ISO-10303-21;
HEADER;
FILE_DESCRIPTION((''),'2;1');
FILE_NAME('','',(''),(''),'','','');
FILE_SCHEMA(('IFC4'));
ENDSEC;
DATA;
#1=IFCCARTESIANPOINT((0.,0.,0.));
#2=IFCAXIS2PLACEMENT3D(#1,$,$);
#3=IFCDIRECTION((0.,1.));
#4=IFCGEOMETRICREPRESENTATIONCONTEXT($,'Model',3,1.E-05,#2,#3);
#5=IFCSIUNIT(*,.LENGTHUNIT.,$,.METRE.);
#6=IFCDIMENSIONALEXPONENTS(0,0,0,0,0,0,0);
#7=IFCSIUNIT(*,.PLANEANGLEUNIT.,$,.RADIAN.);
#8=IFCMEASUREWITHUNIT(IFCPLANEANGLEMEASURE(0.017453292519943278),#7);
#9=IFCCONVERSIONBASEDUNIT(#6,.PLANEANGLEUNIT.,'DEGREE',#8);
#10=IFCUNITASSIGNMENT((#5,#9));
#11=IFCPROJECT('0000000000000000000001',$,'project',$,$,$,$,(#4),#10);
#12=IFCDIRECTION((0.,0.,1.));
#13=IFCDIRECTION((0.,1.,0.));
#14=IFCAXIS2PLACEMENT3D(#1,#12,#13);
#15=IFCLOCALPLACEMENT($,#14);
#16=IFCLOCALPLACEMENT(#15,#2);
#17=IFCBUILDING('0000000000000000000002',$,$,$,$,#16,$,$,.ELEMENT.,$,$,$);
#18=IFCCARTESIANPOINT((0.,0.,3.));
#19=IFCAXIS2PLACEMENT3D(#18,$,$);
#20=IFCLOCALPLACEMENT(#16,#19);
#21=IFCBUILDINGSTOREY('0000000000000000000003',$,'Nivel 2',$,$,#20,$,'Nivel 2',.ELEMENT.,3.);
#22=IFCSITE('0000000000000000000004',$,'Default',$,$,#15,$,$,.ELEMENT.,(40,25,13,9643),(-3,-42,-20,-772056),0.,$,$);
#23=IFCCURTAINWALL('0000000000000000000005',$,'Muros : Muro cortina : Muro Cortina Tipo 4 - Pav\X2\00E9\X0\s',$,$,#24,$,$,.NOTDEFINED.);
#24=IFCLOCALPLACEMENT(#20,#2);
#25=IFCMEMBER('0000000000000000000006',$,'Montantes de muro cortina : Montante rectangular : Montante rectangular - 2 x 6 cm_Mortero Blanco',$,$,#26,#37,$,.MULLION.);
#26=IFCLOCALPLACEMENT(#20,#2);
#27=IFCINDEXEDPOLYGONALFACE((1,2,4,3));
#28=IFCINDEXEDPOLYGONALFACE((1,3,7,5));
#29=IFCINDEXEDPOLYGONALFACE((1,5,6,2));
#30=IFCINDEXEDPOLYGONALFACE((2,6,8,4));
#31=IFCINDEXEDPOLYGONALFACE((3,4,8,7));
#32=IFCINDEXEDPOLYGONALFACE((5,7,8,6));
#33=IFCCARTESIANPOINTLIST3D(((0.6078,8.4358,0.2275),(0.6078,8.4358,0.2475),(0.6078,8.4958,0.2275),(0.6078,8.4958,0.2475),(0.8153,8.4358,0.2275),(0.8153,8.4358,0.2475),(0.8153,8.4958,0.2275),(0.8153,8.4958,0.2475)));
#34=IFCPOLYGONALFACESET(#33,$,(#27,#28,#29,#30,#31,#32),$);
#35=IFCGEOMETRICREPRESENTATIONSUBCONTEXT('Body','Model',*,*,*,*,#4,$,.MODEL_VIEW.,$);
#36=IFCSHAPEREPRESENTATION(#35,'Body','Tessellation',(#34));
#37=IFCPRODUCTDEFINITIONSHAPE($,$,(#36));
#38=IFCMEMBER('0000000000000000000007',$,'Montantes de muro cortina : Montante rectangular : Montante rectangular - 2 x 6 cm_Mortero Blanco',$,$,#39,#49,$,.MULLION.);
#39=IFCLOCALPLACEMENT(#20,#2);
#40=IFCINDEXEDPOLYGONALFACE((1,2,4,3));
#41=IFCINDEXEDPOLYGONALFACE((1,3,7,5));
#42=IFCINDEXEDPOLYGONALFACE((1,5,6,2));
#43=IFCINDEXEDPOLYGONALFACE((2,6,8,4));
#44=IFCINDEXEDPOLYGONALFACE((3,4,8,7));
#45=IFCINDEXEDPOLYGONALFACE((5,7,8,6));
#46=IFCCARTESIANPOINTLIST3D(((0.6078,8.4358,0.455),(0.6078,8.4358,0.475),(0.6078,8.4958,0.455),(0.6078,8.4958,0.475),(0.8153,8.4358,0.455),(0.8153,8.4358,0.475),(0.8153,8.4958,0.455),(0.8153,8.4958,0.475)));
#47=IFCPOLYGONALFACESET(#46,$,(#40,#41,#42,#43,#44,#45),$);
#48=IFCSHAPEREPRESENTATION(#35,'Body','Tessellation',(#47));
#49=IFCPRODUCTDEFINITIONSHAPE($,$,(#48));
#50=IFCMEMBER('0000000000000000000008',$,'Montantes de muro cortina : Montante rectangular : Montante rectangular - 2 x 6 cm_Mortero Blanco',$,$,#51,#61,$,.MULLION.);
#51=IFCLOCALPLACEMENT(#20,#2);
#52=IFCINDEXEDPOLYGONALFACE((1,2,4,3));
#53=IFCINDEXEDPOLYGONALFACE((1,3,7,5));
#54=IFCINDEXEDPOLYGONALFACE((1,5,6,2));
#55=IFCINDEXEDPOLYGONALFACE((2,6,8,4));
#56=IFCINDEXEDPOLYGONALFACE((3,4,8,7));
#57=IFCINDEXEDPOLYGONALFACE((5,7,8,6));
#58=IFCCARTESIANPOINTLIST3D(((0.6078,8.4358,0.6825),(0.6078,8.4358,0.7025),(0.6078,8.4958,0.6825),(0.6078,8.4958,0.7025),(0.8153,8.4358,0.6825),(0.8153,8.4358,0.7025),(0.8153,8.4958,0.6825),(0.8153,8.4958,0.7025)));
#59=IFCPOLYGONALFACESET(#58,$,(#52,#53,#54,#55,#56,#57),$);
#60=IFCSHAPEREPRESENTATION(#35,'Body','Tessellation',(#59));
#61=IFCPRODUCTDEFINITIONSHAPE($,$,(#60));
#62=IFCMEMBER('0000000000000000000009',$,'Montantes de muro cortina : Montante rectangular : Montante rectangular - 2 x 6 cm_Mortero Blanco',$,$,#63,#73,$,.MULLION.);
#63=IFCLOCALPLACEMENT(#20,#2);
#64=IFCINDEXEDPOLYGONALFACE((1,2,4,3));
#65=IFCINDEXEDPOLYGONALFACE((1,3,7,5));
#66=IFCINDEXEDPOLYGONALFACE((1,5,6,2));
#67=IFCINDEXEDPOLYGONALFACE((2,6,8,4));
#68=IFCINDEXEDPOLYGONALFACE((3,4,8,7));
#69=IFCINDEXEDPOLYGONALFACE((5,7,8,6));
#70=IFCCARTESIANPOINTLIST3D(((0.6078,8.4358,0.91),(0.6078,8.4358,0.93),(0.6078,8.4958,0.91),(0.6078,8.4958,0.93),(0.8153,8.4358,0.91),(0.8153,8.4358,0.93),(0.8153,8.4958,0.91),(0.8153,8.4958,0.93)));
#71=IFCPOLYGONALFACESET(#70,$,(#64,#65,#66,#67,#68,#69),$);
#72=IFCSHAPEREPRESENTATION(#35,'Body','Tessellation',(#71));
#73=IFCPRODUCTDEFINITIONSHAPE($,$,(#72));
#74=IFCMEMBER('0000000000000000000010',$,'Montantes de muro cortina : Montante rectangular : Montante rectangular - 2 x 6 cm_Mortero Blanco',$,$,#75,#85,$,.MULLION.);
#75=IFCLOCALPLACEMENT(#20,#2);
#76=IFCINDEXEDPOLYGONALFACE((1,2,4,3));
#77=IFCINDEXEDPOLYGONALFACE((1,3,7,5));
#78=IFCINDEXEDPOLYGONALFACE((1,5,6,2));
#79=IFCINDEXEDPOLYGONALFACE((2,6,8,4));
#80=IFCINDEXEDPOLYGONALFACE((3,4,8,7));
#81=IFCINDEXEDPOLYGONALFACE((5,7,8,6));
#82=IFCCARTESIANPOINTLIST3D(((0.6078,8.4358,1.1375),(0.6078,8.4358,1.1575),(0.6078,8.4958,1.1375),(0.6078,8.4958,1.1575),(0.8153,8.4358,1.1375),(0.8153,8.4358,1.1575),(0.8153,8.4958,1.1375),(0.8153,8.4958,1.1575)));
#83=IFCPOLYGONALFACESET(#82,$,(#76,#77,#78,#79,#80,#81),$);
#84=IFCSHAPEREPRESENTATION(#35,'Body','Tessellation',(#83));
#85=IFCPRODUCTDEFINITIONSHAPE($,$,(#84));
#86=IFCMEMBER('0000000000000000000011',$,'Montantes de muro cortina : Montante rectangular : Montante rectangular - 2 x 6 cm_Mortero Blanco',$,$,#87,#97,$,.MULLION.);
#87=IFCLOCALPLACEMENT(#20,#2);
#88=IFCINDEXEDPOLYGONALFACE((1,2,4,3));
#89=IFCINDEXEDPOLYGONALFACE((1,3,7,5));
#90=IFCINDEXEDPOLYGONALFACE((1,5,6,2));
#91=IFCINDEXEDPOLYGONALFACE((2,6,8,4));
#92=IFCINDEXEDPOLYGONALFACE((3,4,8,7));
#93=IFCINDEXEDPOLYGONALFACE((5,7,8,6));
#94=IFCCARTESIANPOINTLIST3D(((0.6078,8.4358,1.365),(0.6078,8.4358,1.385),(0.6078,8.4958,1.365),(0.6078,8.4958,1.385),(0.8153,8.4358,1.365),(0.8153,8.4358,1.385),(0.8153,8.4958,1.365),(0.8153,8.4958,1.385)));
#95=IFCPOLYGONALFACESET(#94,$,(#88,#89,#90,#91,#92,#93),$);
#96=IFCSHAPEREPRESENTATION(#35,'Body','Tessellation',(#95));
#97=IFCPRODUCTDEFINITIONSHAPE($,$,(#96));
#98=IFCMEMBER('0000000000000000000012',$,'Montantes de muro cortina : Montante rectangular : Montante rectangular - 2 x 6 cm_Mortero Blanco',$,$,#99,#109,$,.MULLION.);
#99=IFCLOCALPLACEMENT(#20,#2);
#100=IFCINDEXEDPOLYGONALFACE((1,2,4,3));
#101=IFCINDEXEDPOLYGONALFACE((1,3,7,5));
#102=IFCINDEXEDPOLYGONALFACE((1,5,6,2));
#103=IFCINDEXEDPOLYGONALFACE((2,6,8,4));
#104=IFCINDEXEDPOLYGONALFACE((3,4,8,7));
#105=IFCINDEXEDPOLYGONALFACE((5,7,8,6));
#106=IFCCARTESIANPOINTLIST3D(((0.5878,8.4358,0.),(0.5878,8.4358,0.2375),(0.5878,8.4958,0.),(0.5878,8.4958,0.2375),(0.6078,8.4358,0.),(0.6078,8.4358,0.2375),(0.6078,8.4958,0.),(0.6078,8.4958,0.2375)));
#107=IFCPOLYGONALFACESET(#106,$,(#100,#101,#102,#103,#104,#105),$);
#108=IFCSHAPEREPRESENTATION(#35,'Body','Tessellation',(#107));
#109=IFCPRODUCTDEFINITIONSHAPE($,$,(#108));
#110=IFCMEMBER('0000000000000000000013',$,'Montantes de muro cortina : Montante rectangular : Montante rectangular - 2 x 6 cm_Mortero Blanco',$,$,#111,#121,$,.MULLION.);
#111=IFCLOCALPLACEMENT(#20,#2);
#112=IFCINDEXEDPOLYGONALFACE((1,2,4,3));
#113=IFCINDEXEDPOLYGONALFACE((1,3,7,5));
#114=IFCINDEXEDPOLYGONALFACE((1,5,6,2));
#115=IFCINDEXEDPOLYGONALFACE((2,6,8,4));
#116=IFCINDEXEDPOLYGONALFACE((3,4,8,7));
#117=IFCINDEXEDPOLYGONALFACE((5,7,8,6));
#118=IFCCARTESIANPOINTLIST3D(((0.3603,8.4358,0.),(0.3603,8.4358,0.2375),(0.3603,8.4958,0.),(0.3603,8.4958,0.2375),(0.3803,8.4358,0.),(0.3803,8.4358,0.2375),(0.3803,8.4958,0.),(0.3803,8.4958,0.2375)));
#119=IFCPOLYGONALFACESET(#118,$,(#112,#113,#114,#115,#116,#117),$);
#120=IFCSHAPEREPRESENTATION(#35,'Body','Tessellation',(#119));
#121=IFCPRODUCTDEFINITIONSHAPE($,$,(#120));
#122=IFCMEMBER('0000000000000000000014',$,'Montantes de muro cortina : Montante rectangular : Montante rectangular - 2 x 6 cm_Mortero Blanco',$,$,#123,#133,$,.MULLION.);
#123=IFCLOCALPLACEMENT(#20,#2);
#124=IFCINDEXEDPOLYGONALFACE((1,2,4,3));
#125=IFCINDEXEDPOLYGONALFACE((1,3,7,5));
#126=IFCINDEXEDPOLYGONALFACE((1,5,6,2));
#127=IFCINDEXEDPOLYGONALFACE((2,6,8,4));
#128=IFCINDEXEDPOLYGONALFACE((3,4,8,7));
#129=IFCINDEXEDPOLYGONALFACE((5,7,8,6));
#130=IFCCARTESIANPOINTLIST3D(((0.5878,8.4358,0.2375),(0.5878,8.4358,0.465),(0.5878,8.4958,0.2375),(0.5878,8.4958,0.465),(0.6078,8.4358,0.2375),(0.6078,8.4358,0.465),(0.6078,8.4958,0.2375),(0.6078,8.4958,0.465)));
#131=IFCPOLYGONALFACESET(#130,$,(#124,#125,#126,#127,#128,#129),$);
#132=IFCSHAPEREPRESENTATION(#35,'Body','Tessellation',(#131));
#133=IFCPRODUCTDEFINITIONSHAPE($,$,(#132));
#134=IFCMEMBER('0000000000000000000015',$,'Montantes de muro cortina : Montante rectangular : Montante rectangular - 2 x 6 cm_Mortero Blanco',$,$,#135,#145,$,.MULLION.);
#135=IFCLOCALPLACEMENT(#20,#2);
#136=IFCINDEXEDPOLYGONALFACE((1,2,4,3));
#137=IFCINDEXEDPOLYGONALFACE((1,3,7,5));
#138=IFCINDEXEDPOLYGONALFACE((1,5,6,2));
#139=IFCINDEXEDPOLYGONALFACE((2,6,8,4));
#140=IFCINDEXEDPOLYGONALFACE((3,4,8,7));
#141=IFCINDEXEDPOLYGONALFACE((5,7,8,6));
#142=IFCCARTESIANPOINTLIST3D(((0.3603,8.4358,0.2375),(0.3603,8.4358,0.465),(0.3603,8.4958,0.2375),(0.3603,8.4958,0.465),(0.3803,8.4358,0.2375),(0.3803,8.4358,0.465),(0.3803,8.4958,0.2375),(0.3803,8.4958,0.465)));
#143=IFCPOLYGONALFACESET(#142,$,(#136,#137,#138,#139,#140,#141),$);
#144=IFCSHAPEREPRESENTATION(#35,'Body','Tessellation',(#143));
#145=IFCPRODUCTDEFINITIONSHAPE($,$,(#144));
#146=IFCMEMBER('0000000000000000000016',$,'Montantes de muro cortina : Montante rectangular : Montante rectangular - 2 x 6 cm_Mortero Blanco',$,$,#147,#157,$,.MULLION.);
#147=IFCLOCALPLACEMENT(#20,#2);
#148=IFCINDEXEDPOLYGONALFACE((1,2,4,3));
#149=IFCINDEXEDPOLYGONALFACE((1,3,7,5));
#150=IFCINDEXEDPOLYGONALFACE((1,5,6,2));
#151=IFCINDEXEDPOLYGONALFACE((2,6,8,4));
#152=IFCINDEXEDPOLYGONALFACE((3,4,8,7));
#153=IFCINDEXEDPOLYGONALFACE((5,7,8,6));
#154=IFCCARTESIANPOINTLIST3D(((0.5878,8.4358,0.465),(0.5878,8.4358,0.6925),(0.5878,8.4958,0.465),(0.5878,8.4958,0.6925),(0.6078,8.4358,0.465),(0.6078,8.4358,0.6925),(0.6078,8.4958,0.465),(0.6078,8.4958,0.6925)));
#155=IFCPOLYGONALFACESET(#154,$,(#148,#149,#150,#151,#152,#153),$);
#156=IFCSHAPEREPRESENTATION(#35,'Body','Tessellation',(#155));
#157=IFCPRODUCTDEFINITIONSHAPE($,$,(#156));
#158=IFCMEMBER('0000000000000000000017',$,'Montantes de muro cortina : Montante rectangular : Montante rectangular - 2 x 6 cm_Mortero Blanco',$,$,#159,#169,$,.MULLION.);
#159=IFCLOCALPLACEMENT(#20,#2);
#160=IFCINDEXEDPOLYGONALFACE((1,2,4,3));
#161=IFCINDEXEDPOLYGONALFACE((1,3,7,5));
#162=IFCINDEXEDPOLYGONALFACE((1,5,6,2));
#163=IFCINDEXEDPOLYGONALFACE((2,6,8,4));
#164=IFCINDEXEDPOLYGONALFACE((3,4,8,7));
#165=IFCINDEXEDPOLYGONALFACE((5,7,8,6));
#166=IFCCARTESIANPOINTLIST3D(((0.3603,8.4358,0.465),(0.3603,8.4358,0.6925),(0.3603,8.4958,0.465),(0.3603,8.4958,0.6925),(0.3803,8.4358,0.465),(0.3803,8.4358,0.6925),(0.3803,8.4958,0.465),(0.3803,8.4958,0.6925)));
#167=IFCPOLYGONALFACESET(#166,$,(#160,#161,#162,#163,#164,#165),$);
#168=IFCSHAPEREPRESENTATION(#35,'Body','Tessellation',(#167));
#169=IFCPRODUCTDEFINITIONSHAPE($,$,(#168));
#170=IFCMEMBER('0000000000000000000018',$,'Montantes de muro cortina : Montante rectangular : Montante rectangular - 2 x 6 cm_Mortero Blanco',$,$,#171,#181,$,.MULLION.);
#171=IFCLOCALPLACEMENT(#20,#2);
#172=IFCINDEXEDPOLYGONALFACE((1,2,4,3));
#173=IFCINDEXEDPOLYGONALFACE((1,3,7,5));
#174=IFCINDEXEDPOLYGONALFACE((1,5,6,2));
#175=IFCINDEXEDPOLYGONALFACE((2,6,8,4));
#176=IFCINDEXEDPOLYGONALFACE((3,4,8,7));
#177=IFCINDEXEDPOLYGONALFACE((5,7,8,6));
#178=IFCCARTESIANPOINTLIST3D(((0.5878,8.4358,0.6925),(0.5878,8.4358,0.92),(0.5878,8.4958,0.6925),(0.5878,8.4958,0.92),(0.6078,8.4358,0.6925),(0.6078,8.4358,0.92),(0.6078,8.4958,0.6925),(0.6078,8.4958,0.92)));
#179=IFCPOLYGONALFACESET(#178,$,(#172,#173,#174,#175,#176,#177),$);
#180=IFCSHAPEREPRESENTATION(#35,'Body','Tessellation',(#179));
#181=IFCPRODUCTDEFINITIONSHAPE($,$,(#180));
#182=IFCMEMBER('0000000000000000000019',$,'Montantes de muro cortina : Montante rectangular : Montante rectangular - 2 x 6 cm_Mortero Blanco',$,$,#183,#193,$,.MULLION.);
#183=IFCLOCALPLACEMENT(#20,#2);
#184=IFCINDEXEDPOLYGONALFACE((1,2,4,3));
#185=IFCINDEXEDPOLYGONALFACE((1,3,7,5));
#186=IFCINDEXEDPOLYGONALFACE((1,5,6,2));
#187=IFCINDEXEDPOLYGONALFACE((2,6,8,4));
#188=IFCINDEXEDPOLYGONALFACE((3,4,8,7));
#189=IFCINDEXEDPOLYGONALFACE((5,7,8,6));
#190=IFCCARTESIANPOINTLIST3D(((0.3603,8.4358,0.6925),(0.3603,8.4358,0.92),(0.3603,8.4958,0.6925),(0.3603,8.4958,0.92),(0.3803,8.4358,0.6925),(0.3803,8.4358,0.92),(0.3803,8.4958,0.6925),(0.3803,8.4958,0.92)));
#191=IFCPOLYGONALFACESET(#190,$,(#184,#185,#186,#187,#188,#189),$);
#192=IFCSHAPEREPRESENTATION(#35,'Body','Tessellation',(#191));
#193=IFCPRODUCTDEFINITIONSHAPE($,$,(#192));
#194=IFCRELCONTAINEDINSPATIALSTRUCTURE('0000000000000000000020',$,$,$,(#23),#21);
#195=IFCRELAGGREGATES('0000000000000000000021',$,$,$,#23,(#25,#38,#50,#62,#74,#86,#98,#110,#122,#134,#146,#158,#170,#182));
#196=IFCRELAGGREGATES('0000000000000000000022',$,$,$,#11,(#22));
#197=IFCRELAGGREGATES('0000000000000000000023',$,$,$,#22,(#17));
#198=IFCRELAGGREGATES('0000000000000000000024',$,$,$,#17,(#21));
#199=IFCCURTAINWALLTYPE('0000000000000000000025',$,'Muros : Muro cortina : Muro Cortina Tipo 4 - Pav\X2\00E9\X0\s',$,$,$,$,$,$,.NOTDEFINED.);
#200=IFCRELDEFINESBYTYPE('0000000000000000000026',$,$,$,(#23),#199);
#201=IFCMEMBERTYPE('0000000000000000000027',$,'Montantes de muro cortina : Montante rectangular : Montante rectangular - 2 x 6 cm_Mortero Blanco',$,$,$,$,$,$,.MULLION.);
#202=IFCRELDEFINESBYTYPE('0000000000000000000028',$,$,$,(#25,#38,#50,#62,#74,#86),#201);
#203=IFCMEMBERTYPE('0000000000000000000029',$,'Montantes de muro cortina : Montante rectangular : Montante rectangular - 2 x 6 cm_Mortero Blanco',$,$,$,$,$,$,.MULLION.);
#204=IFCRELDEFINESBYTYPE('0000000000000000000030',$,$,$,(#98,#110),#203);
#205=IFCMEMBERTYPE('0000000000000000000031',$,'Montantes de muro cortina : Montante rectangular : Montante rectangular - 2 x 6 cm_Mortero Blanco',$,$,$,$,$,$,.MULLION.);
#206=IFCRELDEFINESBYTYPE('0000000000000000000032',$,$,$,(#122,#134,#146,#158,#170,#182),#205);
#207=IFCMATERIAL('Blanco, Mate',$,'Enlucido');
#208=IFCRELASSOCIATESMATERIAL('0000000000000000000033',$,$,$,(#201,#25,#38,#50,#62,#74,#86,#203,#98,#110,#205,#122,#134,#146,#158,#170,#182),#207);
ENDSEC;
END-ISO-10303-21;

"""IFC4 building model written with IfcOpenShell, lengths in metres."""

from ifc_helpers import new_model, entity, si_unit, converted_unit, direction, frame, origin, place, context, subcontext, project, spatial, indexed_curve, outline, extrude, source, transform, mapped, material, type_object, type_shapes, element, aggregate, save


model = new_model("IFC4")

# Units and contexts
model_context = context("Model", 3, precision=1e-05, world=origin(), true_north=direction((0.0, 1.0)))
body_context = subcontext(model_context, "Body", "Model", "MODEL_VIEW")
ifc_project = project(units=[si_unit("LENGTHUNIT", "METRE"), converted_unit("PLANEANGLEUNIT", "DEGREE", entity("IfcPlaneAngleMeasure", 0.017453292519943278), si_unit("PLANEANGLEUNIT", "RADIAN"), dimensions=[0, 0, 0, 0, 0, 0, 0])], contexts=[model_context])

# Site, building, storey
site_placement = place(None, frame((0.0, 0.0, 0.0), z_axis=(0.0, 0.0, 1.0), x_axis=(0.0, 1.0, 0.0)))
site = spatial("IfcSite", under=ifc_project, at=site_placement, Name="Default", CompositionType="ELEMENT", RefLatitude=(40, 25, 13, 9643), RefLongitude=(-3, -42, -20, -772056), RefElevation=0.0)
building_placement = place(site_placement, origin())
building = spatial("IfcBuilding", under=site, at=building_placement, CompositionType="ELEMENT")
storey_placement = place(building_placement, frame((0.0, 0.0, 3.0)))
storey = spatial("IfcBuildingStorey", under=building, at=storey_placement, Name="Nivel 2", LongName="Nivel 2", CompositionType="ELEMENT", Elevation=3.0)

# Curtain wall, members
curtain_wall_type = type_object("IfcCurtainWallType", Name="Muros : Muro cortina : Muro Cortina Tipo 4 - Pavés", PredefinedType="NOTDEFINED")
curtain_wall_placement = place(storey_placement, frame((0.0, 0.0, -3.0)))
curtain_wall = element("IfcCurtainWall", 1, at=curtain_wall_placement, inside=storey, type_object=curtain_wall_type, Name="Muros : Muro cortina : Muro Cortina Tipo 4 - Pavés", PredefinedType="NOTDEFINED")
ifc_material_1 = material(Name="Blanco, Mate", Category="Enlucido")
member_type_1 = type_object("IfcMemberType", Name="Montantes de muro cortina : Montante rectangular : Montante rectangular - 2 x 6 cm_Mortero Blanco", PredefinedType="MULLION", material=ifc_material_1)
shared_shape_1 = source(origin(), body_context, "Body", "SweptSolid", [
    extrude(outline(indexed_curve([(-0.01, -0.03), (0.01, -0.03), (0.01, 0.03), (-0.01, 0.03), (-0.01, -0.03)], self_intersect=False)), frame((0.0, 0.0, -0.2075), z_axis=(0.0, 0.0, 1.0), x_axis=(-1.0, 0.0, 0.0)), (0.0, 0.0, 1.0), 0.2075),
])
type_shapes(member_type_1, [shared_shape_1])
member_1_placement = place(curtain_wall_placement, frame((0.6078, 8.4658, 3.2375), z_axis=(-1.0, 0.0, 0.0), x_axis=(0.0, 0.0, 1.0)))
member_1 = element("IfcMember", 2, at=member_1_placement, type_object=member_type_1, material=ifc_material_1, Name="Montantes de muro cortina : Montante rectangular : Montante rectangular - 2 x 6 cm_Mortero Blanco", PredefinedType="MULLION", context=body_context, shape_type="MappedRepresentation", body=[
    mapped(shared_shape_1, transform((0.0, 0.0, 0.0), scale=1.0)),
])
member_2_placement = place(curtain_wall_placement, frame((0.6078, 8.4658, 3.465), z_axis=(-1.0, 0.0, 0.0), x_axis=(0.0, 0.0, 1.0)))
member_2 = element("IfcMember", 3, at=member_2_placement, type_object=member_type_1, material=ifc_material_1, Name="Montantes de muro cortina : Montante rectangular : Montante rectangular - 2 x 6 cm_Mortero Blanco", PredefinedType="MULLION", context=body_context, shape_type="MappedRepresentation", body=[
    mapped(shared_shape_1, transform((0.0, 0.0, 0.0), scale=1.0)),
])
member_3_placement = place(curtain_wall_placement, frame((0.6078, 8.4658, 3.6925), z_axis=(-1.0, 0.0, 0.0), x_axis=(0.0, 0.0, 1.0)))
member_3 = element("IfcMember", 4, at=member_3_placement, type_object=member_type_1, material=ifc_material_1, Name="Montantes de muro cortina : Montante rectangular : Montante rectangular - 2 x 6 cm_Mortero Blanco", PredefinedType="MULLION", context=body_context, shape_type="MappedRepresentation", body=[
    mapped(shared_shape_1, transform((0.0, 0.0, 0.0), scale=1.0)),
])
member_4_placement = place(curtain_wall_placement, frame((0.6078, 8.4658, 3.92), z_axis=(-1.0, 0.0, 0.0), x_axis=(0.0, 0.0, 1.0)))
member_4 = element("IfcMember", 5, at=member_4_placement, type_object=member_type_1, material=ifc_material_1, Name="Montantes de muro cortina : Montante rectangular : Montante rectangular - 2 x 6 cm_Mortero Blanco", PredefinedType="MULLION", context=body_context, shape_type="MappedRepresentation", body=[
    mapped(shared_shape_1, transform((0.0, 0.0, 0.0), scale=1.0)),
])
member_5_placement = place(curtain_wall_placement, frame((0.6078, 8.4658, 4.1475), z_axis=(-1.0, 0.0, 0.0), x_axis=(0.0, 0.0, 1.0)))
member_5 = element("IfcMember", 6, at=member_5_placement, type_object=member_type_1, material=ifc_material_1, Name="Montantes de muro cortina : Montante rectangular : Montante rectangular - 2 x 6 cm_Mortero Blanco", PredefinedType="MULLION", context=body_context, shape_type="MappedRepresentation", body=[
    mapped(shared_shape_1, transform((0.0, 0.0, 0.0), scale=1.0)),
])
member_6_placement = place(curtain_wall_placement, frame((0.6078, 8.4658, 4.375), z_axis=(-1.0, 0.0, 0.0), x_axis=(0.0, 0.0, 1.0)))
member_6 = element("IfcMember", 7, at=member_6_placement, type_object=member_type_1, material=ifc_material_1, Name="Montantes de muro cortina : Montante rectangular : Montante rectangular - 2 x 6 cm_Mortero Blanco", PredefinedType="MULLION", context=body_context, shape_type="MappedRepresentation", body=[
    mapped(shared_shape_1, transform((0.0, 0.0, 0.0), scale=1.0)),
])
member_type_2 = type_object("IfcMemberType", Name="Montantes de muro cortina : Montante rectangular : Montante rectangular - 2 x 6 cm_Mortero Blanco", PredefinedType="MULLION", material=ifc_material_1)
shared_shape_2 = source(origin(), body_context, "Body", "SweptSolid", [
    extrude(outline(indexed_curve([(-0.01, -0.03), (0.01, -0.03), (0.01, 0.03), (-0.01, 0.03), (-0.01, -0.03)], self_intersect=False)), frame((0.0, 0.0, -0.2375), z_axis=(0.0, 0.0, 1.0), x_axis=(-1.0, 0.0, 0.0)), (0.0, 0.0, 1.0), 0.2375),
])
type_shapes(member_type_2, [shared_shape_2])
member_7_placement = place(curtain_wall_placement, frame((0.5978, 8.4658, 3.0), z_axis=(0.0, 0.0, -1.0), x_axis=(-1.0, 0.0, 0.0)))
member_7 = element("IfcMember", 8, at=member_7_placement, type_object=member_type_2, material=ifc_material_1, Name="Montantes de muro cortina : Montante rectangular : Montante rectangular - 2 x 6 cm_Mortero Blanco", PredefinedType="MULLION", context=body_context, shape_type="MappedRepresentation", body=[
    mapped(shared_shape_2, transform((0.0, 0.0, 0.0), scale=1.0)),
])
member_8_placement = place(curtain_wall_placement, frame((0.3703, 8.4658, 3.0), z_axis=(0.0, 0.0, -1.0), x_axis=(-1.0, 0.0, 0.0)))
member_8 = element("IfcMember", 9, at=member_8_placement, type_object=member_type_2, material=ifc_material_1, Name="Montantes de muro cortina : Montante rectangular : Montante rectangular - 2 x 6 cm_Mortero Blanco", PredefinedType="MULLION", context=body_context, shape_type="MappedRepresentation", body=[
    mapped(shared_shape_2, transform((0.0, 0.0, 0.0), scale=1.0)),
])
member_type_3 = type_object("IfcMemberType", Name="Montantes de muro cortina : Montante rectangular : Montante rectangular - 2 x 6 cm_Mortero Blanco", PredefinedType="MULLION", material=ifc_material_1)
shared_shape_3 = source(origin(), body_context, "Body", "SweptSolid", [
    extrude(outline(indexed_curve([(-0.01, -0.03), (0.01, -0.03), (0.01, 0.03), (-0.01, 0.03), (-0.01, -0.03)], self_intersect=False)), frame((0.0, 0.0, -0.2275), z_axis=(0.0, 0.0, 1.0), x_axis=(-1.0, 0.0, 0.0)), (0.0, 0.0, 1.0), 0.2275),
])
type_shapes(member_type_3, [shared_shape_3])
member_9_placement = place(curtain_wall_placement, frame((0.5978, 8.4658, 3.2375), z_axis=(0.0, 0.0, -1.0), x_axis=(-1.0, 0.0, 0.0)))
member_9 = element("IfcMember", 10, at=member_9_placement, type_object=member_type_3, material=ifc_material_1, Name="Montantes de muro cortina : Montante rectangular : Montante rectangular - 2 x 6 cm_Mortero Blanco", PredefinedType="MULLION", context=body_context, shape_type="MappedRepresentation", body=[
    mapped(shared_shape_3, transform((0.0, 0.0, 0.0), scale=1.0)),
])
member_10_placement = place(curtain_wall_placement, frame((0.3703, 8.4658, 3.2375), z_axis=(0.0, 0.0, -1.0), x_axis=(-1.0, 0.0, 0.0)))
member_10 = element("IfcMember", 11, at=member_10_placement, type_object=member_type_3, material=ifc_material_1, Name="Montantes de muro cortina : Montante rectangular : Montante rectangular - 2 x 6 cm_Mortero Blanco", PredefinedType="MULLION", context=body_context, shape_type="MappedRepresentation", body=[
    mapped(shared_shape_3, transform((0.0, 0.0, 0.0), scale=1.0)),
])
member_11_placement = place(curtain_wall_placement, frame((0.5978, 8.4658, 3.465), z_axis=(0.0, 0.0, -1.0), x_axis=(-1.0, 0.0, 0.0)))
member_11 = element("IfcMember", 12, at=member_11_placement, type_object=member_type_3, material=ifc_material_1, Name="Montantes de muro cortina : Montante rectangular : Montante rectangular - 2 x 6 cm_Mortero Blanco", PredefinedType="MULLION", context=body_context, shape_type="MappedRepresentation", body=[
    mapped(shared_shape_3, transform((0.0, 0.0, 0.0), scale=1.0)),
])
member_12_placement = place(curtain_wall_placement, frame((0.3703, 8.4658, 3.465), z_axis=(0.0, 0.0, -1.0), x_axis=(-1.0, 0.0, 0.0)))
member_12 = element("IfcMember", 13, at=member_12_placement, type_object=member_type_3, material=ifc_material_1, Name="Montantes de muro cortina : Montante rectangular : Montante rectangular - 2 x 6 cm_Mortero Blanco", PredefinedType="MULLION", context=body_context, shape_type="MappedRepresentation", body=[
    mapped(shared_shape_3, transform((0.0, 0.0, 0.0), scale=1.0)),
])
member_13_placement = place(curtain_wall_placement, frame((0.5978, 8.4658, 3.6925), z_axis=(0.0, 0.0, -1.0), x_axis=(-1.0, 0.0, 0.0)))
member_13 = element("IfcMember", 14, at=member_13_placement, type_object=member_type_3, material=ifc_material_1, Name="Montantes de muro cortina : Montante rectangular : Montante rectangular - 2 x 6 cm_Mortero Blanco", PredefinedType="MULLION", context=body_context, shape_type="MappedRepresentation", body=[
    mapped(shared_shape_3, transform((0.0, 0.0, 0.0), scale=1.0)),
])
member_14_placement = place(curtain_wall_placement, frame((0.3703, 8.4658, 3.6925), z_axis=(0.0, 0.0, -1.0), x_axis=(-1.0, 0.0, 0.0)))
member_14 = element("IfcMember", 15, at=member_14_placement, type_object=member_type_3, material=ifc_material_1, Name="Montantes de muro cortina : Montante rectangular : Montante rectangular - 2 x 6 cm_Mortero Blanco", PredefinedType="MULLION", context=body_context, shape_type="MappedRepresentation", body=[
    mapped(shared_shape_3, transform((0.0, 0.0, 0.0), scale=1.0)),
])
aggregate(curtain_wall, [member_1, member_2, member_3, member_4, member_5, member_6, member_7, member_8, member_9, member_10, member_11, member_12, member_13, member_14])

save(model, "model.ifc")
